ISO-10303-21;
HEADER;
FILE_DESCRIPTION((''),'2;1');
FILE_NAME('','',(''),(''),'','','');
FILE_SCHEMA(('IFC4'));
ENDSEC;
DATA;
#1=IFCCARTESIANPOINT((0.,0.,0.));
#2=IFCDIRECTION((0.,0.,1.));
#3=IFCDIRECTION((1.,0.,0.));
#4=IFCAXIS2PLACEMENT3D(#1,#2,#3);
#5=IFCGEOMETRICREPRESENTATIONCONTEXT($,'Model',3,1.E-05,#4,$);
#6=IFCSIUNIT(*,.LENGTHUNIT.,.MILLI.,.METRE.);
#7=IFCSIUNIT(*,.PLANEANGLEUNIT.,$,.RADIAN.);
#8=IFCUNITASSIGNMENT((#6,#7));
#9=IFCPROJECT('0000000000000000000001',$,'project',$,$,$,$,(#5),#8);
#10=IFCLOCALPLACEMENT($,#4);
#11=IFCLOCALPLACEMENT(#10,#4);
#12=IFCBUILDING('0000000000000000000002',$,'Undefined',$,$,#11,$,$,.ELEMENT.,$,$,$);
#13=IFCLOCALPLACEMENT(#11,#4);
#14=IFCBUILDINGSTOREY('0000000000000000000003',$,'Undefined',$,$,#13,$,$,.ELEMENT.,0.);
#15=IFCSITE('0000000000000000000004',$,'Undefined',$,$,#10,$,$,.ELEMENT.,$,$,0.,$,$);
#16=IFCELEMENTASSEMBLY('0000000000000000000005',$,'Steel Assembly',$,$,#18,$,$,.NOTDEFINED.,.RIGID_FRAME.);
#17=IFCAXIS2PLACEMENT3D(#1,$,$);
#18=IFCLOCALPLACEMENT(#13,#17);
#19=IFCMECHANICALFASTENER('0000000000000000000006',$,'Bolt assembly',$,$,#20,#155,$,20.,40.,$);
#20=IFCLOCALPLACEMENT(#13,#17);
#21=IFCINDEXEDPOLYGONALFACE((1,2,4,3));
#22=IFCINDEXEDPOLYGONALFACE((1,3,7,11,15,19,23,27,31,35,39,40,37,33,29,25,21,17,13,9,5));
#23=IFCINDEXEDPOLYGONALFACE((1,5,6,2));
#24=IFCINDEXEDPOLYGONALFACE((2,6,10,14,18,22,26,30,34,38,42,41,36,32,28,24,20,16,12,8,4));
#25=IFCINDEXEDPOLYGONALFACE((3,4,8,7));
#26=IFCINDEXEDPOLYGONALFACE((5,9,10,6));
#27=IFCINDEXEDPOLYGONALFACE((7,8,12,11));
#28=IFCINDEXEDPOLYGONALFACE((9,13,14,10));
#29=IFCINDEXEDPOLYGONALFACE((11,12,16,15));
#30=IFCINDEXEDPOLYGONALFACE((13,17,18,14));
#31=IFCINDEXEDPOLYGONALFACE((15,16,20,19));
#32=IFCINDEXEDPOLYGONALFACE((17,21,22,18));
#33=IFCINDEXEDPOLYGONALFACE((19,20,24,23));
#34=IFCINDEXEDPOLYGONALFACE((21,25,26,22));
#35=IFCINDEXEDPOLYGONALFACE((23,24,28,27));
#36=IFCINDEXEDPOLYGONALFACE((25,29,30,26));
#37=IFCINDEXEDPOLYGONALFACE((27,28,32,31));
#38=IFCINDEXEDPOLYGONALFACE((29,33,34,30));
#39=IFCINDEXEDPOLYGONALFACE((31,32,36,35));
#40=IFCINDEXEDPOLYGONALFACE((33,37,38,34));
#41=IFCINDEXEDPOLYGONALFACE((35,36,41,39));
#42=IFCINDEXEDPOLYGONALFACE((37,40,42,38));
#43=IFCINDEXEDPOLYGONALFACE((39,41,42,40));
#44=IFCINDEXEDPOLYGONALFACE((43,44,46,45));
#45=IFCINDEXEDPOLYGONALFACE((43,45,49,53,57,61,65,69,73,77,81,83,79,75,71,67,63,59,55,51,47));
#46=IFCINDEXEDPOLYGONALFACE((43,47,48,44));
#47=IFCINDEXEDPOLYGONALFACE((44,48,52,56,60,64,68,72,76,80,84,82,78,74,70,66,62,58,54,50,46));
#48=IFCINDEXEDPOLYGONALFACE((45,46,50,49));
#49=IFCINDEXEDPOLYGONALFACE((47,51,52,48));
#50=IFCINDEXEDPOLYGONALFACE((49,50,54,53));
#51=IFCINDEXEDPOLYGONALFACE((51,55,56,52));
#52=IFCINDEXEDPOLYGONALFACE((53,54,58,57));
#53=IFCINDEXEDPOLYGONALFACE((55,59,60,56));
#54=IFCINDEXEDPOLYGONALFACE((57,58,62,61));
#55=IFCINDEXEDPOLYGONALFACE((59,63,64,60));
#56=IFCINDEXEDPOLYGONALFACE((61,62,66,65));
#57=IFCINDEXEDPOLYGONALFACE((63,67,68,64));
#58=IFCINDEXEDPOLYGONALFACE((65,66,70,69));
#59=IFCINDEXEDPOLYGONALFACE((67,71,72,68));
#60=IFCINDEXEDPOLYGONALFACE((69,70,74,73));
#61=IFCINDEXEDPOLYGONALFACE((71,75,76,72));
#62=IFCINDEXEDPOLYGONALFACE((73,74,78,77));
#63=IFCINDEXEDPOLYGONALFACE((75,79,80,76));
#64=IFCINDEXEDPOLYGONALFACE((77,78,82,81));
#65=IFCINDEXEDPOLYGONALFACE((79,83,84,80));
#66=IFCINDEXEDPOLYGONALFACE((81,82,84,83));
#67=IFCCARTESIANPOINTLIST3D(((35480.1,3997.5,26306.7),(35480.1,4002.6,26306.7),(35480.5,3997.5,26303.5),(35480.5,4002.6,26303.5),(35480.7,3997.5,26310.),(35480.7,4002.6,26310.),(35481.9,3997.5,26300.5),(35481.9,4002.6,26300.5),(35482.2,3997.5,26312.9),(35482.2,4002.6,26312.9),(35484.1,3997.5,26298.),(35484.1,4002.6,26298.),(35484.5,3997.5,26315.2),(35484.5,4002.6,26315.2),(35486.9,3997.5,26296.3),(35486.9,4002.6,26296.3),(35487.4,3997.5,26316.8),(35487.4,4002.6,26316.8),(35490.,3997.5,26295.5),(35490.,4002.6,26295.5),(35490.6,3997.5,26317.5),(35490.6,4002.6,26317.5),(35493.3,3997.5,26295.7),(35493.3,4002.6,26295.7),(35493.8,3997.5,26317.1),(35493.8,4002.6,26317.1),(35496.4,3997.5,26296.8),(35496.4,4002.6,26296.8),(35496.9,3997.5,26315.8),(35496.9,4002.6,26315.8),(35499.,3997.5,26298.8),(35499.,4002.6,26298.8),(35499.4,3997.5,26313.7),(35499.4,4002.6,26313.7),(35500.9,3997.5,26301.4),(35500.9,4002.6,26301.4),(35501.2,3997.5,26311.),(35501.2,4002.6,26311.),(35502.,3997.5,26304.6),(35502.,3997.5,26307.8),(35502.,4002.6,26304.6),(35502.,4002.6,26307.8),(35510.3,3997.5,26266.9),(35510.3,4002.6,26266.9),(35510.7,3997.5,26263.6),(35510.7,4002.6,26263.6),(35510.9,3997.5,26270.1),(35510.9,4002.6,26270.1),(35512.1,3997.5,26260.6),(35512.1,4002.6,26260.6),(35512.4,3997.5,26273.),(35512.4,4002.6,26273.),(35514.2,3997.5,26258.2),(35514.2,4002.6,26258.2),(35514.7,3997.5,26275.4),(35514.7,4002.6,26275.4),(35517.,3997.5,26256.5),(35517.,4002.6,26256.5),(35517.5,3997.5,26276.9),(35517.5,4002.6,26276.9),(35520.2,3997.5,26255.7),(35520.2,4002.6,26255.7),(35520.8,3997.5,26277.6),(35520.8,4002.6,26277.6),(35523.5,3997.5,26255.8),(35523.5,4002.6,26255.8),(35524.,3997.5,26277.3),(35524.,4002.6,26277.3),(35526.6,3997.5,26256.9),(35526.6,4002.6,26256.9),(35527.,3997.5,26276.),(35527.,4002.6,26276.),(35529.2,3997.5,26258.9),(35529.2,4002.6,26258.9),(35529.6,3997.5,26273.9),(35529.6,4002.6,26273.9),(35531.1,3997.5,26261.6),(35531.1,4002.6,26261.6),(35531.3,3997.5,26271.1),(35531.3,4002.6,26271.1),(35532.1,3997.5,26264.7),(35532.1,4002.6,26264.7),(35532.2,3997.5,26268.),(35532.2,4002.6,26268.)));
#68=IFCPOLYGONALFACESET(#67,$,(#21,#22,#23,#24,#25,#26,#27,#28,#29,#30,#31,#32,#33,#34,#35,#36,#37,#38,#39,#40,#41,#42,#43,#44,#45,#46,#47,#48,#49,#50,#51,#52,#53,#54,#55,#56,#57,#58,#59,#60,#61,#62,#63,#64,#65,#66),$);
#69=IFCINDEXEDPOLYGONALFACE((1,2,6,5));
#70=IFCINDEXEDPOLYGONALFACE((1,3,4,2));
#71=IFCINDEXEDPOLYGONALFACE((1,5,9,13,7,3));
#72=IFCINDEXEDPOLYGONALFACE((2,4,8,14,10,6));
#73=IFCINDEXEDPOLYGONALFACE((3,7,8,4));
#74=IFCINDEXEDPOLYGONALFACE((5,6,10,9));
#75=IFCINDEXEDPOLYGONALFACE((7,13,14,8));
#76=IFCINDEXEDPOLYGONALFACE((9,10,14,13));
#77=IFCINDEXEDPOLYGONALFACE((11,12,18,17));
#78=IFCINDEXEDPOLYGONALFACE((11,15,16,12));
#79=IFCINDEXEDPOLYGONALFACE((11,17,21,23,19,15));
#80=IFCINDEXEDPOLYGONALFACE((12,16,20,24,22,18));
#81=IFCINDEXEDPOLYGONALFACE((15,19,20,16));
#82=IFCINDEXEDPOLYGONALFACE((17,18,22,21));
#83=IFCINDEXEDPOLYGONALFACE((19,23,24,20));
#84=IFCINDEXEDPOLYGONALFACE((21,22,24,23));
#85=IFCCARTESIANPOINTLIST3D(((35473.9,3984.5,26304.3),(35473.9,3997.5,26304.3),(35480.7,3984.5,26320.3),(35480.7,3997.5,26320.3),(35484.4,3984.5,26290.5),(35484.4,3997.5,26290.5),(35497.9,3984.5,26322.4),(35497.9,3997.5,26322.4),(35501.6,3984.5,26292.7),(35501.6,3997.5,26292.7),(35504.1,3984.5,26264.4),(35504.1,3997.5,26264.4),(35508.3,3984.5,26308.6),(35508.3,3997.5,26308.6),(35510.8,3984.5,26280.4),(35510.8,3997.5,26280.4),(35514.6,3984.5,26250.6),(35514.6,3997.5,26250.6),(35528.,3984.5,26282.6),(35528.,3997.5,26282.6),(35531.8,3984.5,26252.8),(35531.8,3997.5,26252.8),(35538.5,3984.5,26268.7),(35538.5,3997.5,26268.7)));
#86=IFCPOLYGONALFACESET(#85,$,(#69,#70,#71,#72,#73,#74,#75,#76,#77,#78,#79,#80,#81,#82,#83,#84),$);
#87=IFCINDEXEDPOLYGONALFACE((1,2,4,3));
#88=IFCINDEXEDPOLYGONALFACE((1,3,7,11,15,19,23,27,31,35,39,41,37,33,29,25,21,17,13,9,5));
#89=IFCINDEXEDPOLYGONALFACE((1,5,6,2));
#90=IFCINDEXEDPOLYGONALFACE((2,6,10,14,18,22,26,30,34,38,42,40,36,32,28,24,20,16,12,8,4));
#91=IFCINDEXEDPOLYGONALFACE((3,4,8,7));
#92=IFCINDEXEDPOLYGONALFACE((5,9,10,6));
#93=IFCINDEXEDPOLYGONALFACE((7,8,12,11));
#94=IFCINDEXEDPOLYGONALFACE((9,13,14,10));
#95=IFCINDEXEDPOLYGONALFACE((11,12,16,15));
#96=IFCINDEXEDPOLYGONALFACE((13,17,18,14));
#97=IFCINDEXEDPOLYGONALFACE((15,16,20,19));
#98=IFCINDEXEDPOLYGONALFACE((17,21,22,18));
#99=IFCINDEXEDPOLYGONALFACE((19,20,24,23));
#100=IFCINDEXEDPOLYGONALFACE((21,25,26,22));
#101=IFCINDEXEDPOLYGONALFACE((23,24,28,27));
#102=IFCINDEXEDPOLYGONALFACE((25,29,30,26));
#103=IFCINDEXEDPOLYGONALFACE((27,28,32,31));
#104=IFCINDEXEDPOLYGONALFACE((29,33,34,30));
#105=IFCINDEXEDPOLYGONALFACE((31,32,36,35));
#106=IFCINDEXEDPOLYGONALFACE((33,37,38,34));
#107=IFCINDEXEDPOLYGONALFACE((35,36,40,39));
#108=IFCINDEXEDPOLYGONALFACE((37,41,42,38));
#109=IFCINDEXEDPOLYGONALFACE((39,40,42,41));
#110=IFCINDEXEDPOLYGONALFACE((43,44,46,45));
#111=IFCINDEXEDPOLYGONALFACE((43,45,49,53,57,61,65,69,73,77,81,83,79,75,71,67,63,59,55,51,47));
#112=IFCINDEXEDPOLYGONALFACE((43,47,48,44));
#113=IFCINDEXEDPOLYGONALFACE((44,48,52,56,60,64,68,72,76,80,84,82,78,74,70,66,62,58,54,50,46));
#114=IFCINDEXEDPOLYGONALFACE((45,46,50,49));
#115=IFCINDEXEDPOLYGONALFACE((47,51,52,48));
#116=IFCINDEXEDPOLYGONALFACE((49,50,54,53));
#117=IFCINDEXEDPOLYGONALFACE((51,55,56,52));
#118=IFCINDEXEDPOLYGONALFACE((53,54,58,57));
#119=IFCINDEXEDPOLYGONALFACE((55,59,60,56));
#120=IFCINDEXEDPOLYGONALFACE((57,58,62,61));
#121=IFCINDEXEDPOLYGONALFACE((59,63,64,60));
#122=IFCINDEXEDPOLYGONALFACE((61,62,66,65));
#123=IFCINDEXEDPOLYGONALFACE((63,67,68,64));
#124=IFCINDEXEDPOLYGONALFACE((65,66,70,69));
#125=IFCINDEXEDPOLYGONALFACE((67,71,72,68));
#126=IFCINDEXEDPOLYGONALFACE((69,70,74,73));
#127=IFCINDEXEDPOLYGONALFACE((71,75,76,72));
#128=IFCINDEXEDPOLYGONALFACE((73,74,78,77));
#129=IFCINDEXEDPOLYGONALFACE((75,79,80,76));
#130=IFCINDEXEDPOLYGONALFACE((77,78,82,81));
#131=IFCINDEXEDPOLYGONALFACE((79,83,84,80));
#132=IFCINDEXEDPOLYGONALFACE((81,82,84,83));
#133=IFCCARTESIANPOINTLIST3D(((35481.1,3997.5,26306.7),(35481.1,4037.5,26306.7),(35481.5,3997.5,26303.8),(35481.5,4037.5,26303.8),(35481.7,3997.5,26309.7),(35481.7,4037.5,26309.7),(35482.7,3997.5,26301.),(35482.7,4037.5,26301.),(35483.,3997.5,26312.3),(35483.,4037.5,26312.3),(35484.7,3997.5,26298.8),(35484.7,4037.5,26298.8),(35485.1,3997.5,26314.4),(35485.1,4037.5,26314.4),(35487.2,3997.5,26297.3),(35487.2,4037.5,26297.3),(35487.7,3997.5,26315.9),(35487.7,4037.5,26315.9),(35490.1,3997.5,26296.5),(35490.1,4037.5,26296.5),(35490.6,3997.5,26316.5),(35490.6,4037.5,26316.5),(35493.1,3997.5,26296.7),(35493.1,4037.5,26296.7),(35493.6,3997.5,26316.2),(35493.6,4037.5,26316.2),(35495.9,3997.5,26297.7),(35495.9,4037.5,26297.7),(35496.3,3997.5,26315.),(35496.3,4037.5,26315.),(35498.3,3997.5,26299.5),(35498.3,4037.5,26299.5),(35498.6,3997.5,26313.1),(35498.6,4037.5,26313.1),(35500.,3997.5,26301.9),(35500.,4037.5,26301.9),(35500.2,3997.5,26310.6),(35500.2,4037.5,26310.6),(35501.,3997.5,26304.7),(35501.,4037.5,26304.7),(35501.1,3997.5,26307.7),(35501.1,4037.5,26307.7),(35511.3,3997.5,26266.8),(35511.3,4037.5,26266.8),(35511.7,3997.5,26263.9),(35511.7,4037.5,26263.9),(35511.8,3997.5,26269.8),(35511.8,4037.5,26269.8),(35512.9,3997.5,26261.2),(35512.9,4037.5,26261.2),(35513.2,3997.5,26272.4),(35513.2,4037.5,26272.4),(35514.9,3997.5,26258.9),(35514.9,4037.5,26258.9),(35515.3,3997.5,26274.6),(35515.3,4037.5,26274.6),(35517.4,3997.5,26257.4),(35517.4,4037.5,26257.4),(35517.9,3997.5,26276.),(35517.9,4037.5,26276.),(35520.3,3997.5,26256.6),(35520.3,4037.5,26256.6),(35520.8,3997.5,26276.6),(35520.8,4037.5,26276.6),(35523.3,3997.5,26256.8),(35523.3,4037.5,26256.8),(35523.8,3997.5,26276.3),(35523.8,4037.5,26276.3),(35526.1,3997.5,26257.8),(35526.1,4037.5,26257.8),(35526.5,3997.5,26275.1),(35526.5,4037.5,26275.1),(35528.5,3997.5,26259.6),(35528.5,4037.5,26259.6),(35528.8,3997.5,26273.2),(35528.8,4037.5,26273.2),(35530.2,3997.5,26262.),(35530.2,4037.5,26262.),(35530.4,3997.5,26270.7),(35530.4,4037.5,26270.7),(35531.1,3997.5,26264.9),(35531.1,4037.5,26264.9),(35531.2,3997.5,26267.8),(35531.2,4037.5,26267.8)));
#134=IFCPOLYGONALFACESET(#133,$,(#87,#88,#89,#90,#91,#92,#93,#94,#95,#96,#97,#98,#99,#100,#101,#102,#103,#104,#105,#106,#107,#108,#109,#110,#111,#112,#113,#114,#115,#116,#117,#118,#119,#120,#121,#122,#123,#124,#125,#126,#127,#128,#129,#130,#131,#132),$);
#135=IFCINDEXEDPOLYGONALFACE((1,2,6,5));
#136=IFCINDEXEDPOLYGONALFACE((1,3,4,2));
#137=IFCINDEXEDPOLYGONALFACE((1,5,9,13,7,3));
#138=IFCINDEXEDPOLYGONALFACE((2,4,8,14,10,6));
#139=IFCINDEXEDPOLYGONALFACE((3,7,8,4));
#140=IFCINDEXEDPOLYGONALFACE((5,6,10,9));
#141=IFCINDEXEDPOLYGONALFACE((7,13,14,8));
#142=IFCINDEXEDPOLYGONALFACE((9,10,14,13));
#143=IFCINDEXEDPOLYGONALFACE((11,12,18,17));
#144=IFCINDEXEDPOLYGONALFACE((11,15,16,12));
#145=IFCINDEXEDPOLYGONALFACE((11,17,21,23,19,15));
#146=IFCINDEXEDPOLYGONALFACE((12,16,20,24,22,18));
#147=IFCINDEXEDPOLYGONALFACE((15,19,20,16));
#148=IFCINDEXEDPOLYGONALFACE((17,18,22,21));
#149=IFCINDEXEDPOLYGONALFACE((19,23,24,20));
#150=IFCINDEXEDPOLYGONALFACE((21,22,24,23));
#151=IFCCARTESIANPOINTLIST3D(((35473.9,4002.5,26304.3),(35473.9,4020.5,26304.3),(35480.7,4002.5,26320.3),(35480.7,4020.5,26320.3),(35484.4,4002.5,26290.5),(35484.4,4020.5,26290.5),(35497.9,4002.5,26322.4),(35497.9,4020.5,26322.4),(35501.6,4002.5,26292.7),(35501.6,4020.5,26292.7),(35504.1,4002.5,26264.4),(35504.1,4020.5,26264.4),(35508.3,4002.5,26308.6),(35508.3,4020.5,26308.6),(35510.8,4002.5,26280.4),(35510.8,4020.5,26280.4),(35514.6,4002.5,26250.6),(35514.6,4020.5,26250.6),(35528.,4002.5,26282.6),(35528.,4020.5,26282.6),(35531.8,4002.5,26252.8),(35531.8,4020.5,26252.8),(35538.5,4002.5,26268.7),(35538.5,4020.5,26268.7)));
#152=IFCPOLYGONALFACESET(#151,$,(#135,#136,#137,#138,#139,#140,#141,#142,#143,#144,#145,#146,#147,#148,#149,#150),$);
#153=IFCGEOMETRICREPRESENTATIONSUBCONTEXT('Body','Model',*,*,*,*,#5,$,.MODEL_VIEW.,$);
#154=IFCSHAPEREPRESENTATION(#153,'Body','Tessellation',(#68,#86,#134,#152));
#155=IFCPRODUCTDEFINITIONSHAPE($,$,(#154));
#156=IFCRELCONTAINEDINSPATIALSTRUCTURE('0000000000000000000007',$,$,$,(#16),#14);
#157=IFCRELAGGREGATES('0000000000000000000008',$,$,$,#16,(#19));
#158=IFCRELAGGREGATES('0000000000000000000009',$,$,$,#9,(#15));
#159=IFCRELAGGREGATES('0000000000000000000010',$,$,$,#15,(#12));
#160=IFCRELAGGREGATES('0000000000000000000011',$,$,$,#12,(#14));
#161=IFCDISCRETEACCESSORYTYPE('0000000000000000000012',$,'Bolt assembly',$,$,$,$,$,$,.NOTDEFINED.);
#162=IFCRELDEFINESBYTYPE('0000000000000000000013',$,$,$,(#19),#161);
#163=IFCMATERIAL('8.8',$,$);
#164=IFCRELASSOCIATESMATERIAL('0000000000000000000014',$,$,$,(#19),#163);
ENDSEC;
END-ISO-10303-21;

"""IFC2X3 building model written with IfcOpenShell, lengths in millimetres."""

from ifc_helpers import new_model, si_unit, frame, origin_with_axes, origin_2d_with_axis, place, context, subcontext, project, spatial, polyline, circle, outline, extrude, source, transform, mapped, material, type_object, element, aggregate, save


model = new_model("IFC2X3")

# Units and contexts
model_context = context("Model", 3, precision=1e-05, world=origin_with_axes())
body_context = subcontext(model_context, "Body", "Model", "MODEL_VIEW")
ifc_project = project(units=[si_unit("LENGTHUNIT", "METRE", prefix="MILLI"), si_unit("PLANEANGLEUNIT", "RADIAN")], contexts=[model_context])

# Site, building, storey
site_placement = place(None, origin_with_axes())
site = spatial("IfcSite", under=ifc_project, at=site_placement, Name="Undefined", CompositionType="ELEMENT", RefElevation=0.0)
building_placement = place(site_placement, origin_with_axes())
building = spatial("IfcBuilding", under=site, at=building_placement, Name="Undefined", CompositionType="ELEMENT")
storey_placement = place(building_placement, origin_with_axes())
storey = spatial("IfcBuildingStorey", under=building, at=storey_placement, Name="Undefined", CompositionType="ELEMENT", Elevation=0.0)

# Element assembly
assembly_1_placement = place(storey_placement, origin_with_axes())
assembly_1 = element("IfcElementAssembly", 1, at=assembly_1_placement, inside=storey, Name="Steel Assembly", AssemblyPlace="NOTDEFINED", PredefinedType="RIGID_FRAME")

# Shared definitions
discrete_accessory_type_1 = type_object("IfcDiscreteAccessoryType", Name="Bolt assembly")
ifc_material_1 = material(Name="8.8")

# Mechanical fastener
shared_shape_1 = source(origin_with_axes(), body_context, "Body", "SweptSolid", [
    extrude(circle(Radius=11.0, at=origin_2d_with_axis()), frame((0.0, -2.5, 0.0), z_axis=(0.0, 1.0, 0.0), x_axis=(1.0, 0.0, 0.0)), (0.0, 0.0, 1.0), 5.1),
    extrude(outline(polyline([(17.3, 0.0), (8.7, 15.0), (-8.7, 15.0), (-17.3, 0.0), (-8.7, -15.0), (8.7, -15.0), (17.3, 0.0)])), frame((0.0, -15.5, 0.0), z_axis=(0.0, 1.0, 0.0), x_axis=(1.0, 0.0, 0.0)), (0.0, 0.0, 1.0), 13.0),
    extrude(circle(Radius=10.0, at=origin_2d_with_axis()), frame((0.0, -2.5, 0.0), z_axis=(0.0, 1.0, 0.0), x_axis=(1.0, 0.0, 0.0)), (0.0, 0.0, 1.0), 40.0),
    extrude(outline(polyline([(17.3, 0.0), (8.7, 15.0), (-8.7, 15.0), (-17.3, 0.0), (-8.7, -15.0), (8.7, -15.0), (17.3, 0.0)])), frame((0.0, 2.5, 0.0), z_axis=(0.0, 1.0, 0.0), x_axis=(1.0, 0.0, 0.0)), (0.0, 0.0, 1.0), 18.0),
])
mechanical_fastener_1_placement = place(assembly_1_placement, frame((35521.3, 4000.0, 26266.6), z_axis=(-0.797403, 0.0, -0.603447), x_axis=(-0.603447, 0.0, 0.797403)))
mechanical_fastener_1 = element("IfcMechanicalFastener", 2, at=mechanical_fastener_1_placement, type_object=discrete_accessory_type_1, material=ifc_material_1, Name="Bolt assembly", NominalDiameter=20.0, NominalLength=40.0, context=body_context, shape_type="MappedRepresentation", body=[
    mapped(shared_shape_1, transform((0.0, 0.0, 0.0))),
    mapped(shared_shape_1, transform((50.0, 0.0, 0.0))),
])
aggregate(assembly_1, [mechanical_fastener_1])

save(model, "model.ifc")
